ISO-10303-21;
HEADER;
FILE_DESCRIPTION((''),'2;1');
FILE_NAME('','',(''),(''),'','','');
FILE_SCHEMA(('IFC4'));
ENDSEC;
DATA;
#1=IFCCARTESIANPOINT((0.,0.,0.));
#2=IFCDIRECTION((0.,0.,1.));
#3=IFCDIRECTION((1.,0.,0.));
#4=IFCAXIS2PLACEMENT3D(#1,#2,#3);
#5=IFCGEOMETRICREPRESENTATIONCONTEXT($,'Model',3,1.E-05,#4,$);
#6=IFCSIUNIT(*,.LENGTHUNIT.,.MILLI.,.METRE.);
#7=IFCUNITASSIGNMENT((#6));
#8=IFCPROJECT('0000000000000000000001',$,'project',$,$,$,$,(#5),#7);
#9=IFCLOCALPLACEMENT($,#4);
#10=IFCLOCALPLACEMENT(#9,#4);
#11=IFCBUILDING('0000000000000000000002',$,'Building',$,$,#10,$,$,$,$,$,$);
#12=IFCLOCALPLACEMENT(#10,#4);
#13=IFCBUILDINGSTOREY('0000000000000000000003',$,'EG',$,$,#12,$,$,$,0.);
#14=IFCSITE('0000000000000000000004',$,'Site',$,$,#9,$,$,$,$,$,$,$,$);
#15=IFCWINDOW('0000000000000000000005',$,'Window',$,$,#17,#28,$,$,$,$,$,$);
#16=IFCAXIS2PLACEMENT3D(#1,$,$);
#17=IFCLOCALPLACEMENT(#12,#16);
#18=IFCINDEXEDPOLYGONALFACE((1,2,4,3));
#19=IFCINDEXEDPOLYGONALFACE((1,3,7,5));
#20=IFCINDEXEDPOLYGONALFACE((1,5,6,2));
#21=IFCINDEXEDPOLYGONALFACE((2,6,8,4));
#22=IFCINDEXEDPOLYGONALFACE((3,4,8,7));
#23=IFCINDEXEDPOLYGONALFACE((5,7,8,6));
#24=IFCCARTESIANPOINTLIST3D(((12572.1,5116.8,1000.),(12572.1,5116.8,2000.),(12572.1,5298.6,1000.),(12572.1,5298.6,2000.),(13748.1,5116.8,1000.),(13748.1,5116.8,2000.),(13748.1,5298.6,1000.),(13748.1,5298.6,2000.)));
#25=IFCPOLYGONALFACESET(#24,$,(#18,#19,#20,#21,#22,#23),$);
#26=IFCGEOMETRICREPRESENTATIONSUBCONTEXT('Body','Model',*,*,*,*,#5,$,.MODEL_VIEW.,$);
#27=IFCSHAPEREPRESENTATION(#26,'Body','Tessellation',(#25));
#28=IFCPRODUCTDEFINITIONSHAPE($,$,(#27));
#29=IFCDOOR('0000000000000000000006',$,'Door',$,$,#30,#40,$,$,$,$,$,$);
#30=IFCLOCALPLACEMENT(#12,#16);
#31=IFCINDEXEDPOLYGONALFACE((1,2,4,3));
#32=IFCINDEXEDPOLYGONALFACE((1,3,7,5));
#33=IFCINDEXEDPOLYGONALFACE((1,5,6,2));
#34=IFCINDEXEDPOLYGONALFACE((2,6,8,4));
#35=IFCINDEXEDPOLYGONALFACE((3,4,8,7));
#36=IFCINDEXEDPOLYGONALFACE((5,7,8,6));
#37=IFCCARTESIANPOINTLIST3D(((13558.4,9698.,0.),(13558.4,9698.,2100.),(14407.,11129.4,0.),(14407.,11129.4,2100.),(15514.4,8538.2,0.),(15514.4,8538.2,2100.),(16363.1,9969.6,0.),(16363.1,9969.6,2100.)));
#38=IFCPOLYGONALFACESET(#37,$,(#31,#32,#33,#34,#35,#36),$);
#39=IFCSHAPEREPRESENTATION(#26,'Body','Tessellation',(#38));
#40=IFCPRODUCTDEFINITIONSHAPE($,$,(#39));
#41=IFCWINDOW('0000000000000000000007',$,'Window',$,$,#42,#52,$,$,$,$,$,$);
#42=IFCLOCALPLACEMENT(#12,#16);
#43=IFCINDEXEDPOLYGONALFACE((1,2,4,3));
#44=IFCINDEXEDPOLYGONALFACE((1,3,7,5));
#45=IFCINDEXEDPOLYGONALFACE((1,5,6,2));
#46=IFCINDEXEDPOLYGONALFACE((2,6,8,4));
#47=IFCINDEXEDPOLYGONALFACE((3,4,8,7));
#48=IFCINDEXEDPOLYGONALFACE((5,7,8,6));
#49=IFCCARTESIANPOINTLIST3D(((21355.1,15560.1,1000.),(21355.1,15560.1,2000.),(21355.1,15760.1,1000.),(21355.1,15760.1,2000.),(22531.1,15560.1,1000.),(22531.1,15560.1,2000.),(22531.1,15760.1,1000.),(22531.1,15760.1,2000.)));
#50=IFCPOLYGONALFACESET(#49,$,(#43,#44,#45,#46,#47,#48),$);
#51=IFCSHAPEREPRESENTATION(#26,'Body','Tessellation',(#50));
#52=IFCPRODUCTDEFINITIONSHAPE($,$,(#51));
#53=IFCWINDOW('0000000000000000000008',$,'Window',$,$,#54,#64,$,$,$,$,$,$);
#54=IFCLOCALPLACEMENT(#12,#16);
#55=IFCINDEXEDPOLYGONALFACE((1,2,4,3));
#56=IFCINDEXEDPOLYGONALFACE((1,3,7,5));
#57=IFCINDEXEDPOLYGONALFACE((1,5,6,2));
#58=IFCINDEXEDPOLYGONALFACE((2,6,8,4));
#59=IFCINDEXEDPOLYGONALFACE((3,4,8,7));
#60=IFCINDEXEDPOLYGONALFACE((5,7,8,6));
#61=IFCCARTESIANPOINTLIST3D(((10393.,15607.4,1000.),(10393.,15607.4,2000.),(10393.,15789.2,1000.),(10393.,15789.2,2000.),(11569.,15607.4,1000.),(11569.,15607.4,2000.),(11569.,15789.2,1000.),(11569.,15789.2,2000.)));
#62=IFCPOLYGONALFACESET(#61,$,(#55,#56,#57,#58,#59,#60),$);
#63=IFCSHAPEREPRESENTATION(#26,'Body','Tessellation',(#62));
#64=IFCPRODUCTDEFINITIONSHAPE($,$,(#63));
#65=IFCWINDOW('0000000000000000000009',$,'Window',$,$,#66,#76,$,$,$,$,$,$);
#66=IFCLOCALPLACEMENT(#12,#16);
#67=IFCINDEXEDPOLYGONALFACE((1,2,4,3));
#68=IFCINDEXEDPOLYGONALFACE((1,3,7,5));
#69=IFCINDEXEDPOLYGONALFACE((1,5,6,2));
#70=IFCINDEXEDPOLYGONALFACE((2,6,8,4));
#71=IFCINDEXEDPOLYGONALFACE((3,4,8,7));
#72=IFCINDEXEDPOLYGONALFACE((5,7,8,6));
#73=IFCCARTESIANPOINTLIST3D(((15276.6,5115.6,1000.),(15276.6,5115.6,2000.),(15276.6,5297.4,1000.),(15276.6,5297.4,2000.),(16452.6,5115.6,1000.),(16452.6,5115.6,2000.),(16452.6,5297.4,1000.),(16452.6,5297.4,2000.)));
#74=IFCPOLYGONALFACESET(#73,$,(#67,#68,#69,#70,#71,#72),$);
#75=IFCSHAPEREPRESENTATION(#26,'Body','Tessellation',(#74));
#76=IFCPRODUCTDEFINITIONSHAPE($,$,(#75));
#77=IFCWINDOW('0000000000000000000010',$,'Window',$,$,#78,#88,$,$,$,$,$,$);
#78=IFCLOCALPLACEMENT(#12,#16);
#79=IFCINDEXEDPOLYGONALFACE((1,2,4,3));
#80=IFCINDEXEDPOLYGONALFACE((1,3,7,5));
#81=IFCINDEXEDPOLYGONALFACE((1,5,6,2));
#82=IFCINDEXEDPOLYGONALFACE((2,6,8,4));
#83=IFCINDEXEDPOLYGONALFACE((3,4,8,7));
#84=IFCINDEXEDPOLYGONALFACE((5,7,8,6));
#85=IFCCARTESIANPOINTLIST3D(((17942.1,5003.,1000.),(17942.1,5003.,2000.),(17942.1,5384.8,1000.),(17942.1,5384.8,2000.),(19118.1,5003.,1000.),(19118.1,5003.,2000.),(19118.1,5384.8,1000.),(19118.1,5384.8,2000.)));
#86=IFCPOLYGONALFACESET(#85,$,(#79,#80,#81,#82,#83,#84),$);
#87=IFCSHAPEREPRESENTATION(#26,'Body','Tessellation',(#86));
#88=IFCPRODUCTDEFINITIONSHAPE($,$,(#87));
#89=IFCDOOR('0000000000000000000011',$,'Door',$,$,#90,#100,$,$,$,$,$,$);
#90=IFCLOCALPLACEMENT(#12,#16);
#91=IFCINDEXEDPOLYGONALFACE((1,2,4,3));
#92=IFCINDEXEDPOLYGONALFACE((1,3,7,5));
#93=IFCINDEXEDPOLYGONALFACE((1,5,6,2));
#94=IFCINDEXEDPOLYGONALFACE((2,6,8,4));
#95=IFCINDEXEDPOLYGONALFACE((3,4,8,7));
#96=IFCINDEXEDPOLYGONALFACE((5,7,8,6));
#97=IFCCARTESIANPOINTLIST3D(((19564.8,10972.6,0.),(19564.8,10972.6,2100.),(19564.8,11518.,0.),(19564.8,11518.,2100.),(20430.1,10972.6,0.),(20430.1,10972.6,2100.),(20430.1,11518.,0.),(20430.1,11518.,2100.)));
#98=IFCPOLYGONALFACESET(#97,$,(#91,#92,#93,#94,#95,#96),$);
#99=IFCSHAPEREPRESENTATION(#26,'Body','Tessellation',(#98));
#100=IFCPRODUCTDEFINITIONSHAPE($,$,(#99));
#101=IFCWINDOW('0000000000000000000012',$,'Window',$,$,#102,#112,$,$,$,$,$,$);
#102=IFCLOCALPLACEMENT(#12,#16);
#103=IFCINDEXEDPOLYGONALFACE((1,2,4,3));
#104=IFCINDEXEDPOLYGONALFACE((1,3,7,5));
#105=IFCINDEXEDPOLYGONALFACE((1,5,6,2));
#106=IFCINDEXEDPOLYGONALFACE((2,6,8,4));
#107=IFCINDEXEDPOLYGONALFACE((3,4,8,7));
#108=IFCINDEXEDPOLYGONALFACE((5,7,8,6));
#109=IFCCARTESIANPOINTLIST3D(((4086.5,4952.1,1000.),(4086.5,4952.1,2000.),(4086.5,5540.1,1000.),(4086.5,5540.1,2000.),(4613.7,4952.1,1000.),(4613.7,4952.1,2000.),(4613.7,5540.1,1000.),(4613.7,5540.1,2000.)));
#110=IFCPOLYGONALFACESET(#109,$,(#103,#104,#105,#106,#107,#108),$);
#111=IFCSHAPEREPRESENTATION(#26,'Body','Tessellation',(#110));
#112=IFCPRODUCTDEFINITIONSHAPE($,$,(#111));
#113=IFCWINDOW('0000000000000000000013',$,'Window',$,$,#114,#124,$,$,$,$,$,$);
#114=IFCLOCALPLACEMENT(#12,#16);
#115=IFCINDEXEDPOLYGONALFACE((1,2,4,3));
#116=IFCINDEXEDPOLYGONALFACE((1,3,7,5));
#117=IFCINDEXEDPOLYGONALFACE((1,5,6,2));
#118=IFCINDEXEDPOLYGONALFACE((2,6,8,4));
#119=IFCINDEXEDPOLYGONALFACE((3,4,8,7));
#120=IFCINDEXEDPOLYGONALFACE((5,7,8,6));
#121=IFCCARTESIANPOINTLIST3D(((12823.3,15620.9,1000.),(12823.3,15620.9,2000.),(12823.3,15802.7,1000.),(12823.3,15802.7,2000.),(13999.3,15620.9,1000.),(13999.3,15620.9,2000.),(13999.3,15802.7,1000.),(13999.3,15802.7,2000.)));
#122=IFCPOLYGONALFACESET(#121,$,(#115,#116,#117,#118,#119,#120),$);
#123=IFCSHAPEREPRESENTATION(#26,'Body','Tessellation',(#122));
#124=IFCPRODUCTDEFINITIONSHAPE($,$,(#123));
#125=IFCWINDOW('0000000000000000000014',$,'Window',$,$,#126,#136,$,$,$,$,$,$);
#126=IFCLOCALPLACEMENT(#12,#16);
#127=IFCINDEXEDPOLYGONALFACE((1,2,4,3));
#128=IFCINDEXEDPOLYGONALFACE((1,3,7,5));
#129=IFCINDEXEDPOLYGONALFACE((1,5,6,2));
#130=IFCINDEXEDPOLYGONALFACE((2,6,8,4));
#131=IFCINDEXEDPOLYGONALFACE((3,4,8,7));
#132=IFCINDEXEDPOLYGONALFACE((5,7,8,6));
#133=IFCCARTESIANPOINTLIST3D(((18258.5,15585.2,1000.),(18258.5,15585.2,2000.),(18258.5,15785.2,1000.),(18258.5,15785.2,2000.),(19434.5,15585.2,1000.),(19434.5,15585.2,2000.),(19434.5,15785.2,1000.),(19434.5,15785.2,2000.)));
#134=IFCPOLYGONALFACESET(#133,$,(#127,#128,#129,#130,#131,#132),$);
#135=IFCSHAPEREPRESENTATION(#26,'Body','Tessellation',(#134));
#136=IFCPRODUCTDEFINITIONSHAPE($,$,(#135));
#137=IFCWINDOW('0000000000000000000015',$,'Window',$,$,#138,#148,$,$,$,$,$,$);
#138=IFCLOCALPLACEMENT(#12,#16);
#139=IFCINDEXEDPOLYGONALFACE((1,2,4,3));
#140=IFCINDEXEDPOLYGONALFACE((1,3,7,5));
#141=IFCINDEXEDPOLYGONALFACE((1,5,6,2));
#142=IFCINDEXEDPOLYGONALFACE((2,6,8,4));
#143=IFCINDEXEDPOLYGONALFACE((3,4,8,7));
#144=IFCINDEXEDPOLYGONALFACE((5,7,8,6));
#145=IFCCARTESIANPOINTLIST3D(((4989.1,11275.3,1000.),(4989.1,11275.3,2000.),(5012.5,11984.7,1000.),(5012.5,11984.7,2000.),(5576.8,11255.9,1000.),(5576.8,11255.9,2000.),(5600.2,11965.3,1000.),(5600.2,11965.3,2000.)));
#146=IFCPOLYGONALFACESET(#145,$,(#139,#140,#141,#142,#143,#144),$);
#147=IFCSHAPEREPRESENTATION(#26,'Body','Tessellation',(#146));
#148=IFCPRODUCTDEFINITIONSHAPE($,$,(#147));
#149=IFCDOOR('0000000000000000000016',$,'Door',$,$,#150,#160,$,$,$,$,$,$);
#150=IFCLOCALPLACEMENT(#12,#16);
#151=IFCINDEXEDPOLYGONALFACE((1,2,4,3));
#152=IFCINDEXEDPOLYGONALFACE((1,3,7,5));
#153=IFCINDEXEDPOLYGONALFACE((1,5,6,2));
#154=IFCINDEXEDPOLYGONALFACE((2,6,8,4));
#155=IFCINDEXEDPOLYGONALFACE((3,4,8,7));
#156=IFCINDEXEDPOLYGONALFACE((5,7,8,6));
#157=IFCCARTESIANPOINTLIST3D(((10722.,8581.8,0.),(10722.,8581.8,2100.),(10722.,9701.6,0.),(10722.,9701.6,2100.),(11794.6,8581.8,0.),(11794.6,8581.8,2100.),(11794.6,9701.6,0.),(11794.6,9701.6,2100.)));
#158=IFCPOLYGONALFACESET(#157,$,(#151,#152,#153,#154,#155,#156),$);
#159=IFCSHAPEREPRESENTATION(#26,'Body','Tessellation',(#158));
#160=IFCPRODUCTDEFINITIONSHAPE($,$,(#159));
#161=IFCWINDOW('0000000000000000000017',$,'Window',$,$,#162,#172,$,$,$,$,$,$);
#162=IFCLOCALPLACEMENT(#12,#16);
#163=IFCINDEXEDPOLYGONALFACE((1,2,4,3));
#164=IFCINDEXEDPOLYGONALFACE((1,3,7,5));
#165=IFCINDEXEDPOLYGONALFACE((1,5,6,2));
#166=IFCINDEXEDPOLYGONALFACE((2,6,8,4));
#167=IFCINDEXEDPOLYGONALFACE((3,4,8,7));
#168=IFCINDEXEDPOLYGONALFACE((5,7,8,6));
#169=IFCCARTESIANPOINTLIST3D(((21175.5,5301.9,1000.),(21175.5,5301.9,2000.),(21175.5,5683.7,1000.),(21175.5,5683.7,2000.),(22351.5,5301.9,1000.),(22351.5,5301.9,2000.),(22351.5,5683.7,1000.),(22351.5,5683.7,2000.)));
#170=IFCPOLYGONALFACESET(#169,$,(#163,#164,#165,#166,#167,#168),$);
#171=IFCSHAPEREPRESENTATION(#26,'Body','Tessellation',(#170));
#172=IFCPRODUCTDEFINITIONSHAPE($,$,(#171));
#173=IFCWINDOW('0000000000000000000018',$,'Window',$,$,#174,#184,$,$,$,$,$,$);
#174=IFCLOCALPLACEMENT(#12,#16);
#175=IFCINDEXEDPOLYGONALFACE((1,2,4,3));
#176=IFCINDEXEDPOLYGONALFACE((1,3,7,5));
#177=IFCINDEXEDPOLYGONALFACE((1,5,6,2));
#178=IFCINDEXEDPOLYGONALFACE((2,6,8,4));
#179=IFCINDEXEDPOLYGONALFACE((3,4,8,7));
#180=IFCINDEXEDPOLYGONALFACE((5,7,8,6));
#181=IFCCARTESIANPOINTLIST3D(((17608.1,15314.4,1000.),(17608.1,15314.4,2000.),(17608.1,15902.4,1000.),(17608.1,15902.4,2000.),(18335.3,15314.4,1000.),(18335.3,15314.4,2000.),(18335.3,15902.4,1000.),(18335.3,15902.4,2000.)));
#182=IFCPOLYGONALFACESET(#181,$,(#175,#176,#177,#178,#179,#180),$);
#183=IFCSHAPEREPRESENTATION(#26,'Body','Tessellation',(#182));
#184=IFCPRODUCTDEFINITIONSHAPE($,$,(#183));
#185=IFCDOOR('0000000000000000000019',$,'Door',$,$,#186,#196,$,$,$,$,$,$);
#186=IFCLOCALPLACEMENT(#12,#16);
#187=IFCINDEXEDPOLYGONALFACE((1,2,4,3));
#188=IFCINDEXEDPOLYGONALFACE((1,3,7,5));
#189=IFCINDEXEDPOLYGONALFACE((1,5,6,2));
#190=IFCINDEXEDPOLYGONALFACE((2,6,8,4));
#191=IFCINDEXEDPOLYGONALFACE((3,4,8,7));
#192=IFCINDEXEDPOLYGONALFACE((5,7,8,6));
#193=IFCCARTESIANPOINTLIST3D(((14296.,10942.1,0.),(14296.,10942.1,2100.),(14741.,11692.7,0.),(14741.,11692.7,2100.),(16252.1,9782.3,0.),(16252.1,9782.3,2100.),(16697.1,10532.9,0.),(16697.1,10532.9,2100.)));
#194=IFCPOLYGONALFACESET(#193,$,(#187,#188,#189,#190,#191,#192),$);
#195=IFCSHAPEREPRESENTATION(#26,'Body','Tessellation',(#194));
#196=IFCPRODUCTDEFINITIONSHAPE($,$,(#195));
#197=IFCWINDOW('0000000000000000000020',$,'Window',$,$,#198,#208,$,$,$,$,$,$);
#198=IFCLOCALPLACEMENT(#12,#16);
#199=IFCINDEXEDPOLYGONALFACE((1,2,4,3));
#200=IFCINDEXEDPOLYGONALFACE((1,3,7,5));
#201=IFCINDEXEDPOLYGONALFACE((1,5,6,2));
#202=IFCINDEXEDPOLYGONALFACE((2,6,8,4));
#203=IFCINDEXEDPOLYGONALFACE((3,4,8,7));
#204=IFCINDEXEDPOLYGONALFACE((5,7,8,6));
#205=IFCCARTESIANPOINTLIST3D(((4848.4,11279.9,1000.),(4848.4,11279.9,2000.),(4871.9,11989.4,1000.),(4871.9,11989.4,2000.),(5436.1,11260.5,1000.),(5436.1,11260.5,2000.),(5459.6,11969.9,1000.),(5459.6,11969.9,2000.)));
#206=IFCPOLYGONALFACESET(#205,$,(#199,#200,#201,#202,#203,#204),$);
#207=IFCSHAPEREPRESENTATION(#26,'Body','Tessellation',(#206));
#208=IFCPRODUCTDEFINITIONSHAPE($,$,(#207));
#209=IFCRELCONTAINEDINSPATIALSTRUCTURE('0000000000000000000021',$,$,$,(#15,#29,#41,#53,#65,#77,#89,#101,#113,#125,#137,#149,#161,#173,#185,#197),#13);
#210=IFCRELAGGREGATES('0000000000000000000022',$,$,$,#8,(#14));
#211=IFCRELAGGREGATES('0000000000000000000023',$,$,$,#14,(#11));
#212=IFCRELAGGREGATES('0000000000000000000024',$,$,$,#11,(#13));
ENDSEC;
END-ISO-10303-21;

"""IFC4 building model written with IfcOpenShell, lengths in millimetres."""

from ifc_helpers import new_model, si_unit, frame, origin_with_axes, place, context, subcontext, project, spatial, rectangle, extrude, element, save


model = new_model("IFC4")

# Units and contexts
model_context = context("Model", 3, precision=1e-05, world=origin_with_axes())
body_context = subcontext(model_context, "Body", "Model", "MODEL_VIEW")
ifc_project = project(units=[si_unit("LENGTHUNIT", "METRE", prefix="MILLI")], contexts=[model_context])

# Site, building, storey
site_placement = place(None, origin_with_axes())
site = spatial("IfcSite", under=ifc_project, at=site_placement, Name="Site")
building_placement = place(site_placement, origin_with_axes())
building = spatial("IfcBuilding", under=site, at=building_placement, Name="Building")
storey_placement = place(building_placement, origin_with_axes())
storey = spatial("IfcBuildingStorey", under=building, at=storey_placement, Name="EG", Elevation=0.0)

# Window
window_1_placement = place(storey_placement, origin_with_axes())
element("IfcWindow", 1, at=window_1_placement, inside=storey, Name="Window", context=body_context, shape_type="SweptSolid", body=[
    extrude(rectangle(XDim=1176.0, YDim=181.8), frame((13160.1, 5207.7, 1000.0), z_axis=(0.0, 0.0, 1.0), x_axis=(1.0, 0.0, 0.0)), (0.0, 0.0, 1.0), 1000.0),
])

# Door
door_1_placement = place(storey_placement, origin_with_axes())
element("IfcDoor", 2, at=door_1_placement, inside=storey, Name="Door", context=body_context, shape_type="SweptSolid", body=[
    extrude(rectangle(XDim=1664.0, YDim=2274.1), frame((14960.7, 9833.8, 0.0), z_axis=(0.0, 0.0, 1.0), x_axis=(-0.510011, -0.860168, 0.0)), (0.0, 0.0, 1.0), 2100.0),
])

# Windows
window_2_placement = place(storey_placement, origin_with_axes())
element("IfcWindow", 3, at=window_2_placement, inside=storey, Name="Window", context=body_context, shape_type="SweptSolid", body=[
    extrude(rectangle(XDim=1176.0, YDim=200.0), frame((21943.1, 15660.1, 1000.0), z_axis=(0.0, 0.0, 1.0), x_axis=(1.0, 0.0, 0.0)), (0.0, 0.0, 1.0), 1000.0),
])
window_3_placement = place(storey_placement, origin_with_axes())
element("IfcWindow", 4, at=window_3_placement, inside=storey, Name="Window", context=body_context, shape_type="SweptSolid", body=[
    extrude(rectangle(XDim=1176.0, YDim=181.8), frame((10981.0, 15698.3, 1000.0), z_axis=(0.0, 0.0, 1.0), x_axis=(1.0, 0.0, 0.0)), (0.0, 0.0, 1.0), 1000.0),
])
window_4_placement = place(storey_placement, origin_with_axes())
element("IfcWindow", 5, at=window_4_placement, inside=storey, Name="Window", context=body_context, shape_type="SweptSolid", body=[
    extrude(rectangle(XDim=1176.0, YDim=181.8), frame((15864.6, 5206.5, 1000.0), z_axis=(0.0, 0.0, 1.0), x_axis=(1.0, 0.0, 0.0)), (0.0, 0.0, 1.0), 1000.0),
])
window_5_placement = place(storey_placement, origin_with_axes())
element("IfcWindow", 6, at=window_5_placement, inside=storey, Name="Window", context=body_context, shape_type="SweptSolid", body=[
    extrude(rectangle(XDim=1176.0, YDim=381.8), frame((18530.1, 5193.9, 1000.0), z_axis=(0.0, 0.0, 1.0), x_axis=(1.0, 0.0, 0.0)), (0.0, 0.0, 1.0), 1000.0),
])

# Door
door_2_placement = place(storey_placement, origin_with_axes())
element("IfcDoor", 7, at=door_2_placement, inside=storey, Name="Door", context=body_context, shape_type="SweptSolid", body=[
    extrude(rectangle(XDim=865.3, YDim=545.4), frame((19997.4, 11245.3, 0.0), z_axis=(0.0, 0.0, 1.0), x_axis=(1.0, 0.0, 0.0)), (0.0, 0.0, 1.0), 2100.0),
])

# Windows
window_6_placement = place(storey_placement, origin_with_axes())
element("IfcWindow", 8, at=window_6_placement, inside=storey, Name="Window", context=body_context, shape_type="SweptSolid", body=[
    extrude(rectangle(XDim=588.0, YDim=527.2), frame((4350.1, 5246.1, 1000.0), z_axis=(0.0, 0.0, 1.0), x_axis=(0.0, 1.0, 0.0)), (0.0, 0.0, 1.0), 1000.0),
])
window_7_placement = place(storey_placement, origin_with_axes())
element("IfcWindow", 9, at=window_7_placement, inside=storey, Name="Window", context=body_context, shape_type="SweptSolid", body=[
    extrude(rectangle(XDim=1176.0, YDim=181.8), frame((13411.3, 15711.8, 1000.0), z_axis=(0.0, 0.0, 1.0), x_axis=(1.0, 0.0, 0.0)), (0.0, 0.0, 1.0), 1000.0),
])
window_8_placement = place(storey_placement, origin_with_axes())
element("IfcWindow", 10, at=window_8_placement, inside=storey, Name="Window", context=body_context, shape_type="SweptSolid", body=[
    extrude(rectangle(XDim=1176.0, YDim=200.0), frame((18846.5, 15685.2, 1000.0), z_axis=(0.0, 0.0, 1.0), x_axis=(1.0, 0.0, 0.0)), (0.0, 0.0, 1.0), 1000.0),
])
window_9_placement = place(storey_placement, origin_with_axes())
element("IfcWindow", 11, at=window_9_placement, inside=storey, Name="Window", context=body_context, shape_type="SweptSolid", body=[
    extrude(rectangle(XDim=588.0, YDim=709.8), frame((5294.6, 11620.3, 1000.0), z_axis=(0.0, 0.0, 1.0), x_axis=(0.999454, -0.03304, 0.0)), (0.0, 0.0, 1.0), 1000.0),
])

# Door
door_3_placement = place(storey_placement, origin_with_axes())
element("IfcDoor", 12, at=door_3_placement, inside=storey, Name="Door", context=body_context, shape_type="SweptSolid", body=[
    extrude(rectangle(XDim=1119.9, YDim=1072.6), frame((11258.3, 9141.7, 0.0), z_axis=(0.0, 0.0, 1.0), x_axis=(0.0, 1.0, 0.0)), (0.0, 0.0, 1.0), 2100.0),
])

# Windows
window_10_placement = place(storey_placement, origin_with_axes())
element("IfcWindow", 13, at=window_10_placement, inside=storey, Name="Window", context=body_context, shape_type="SweptSolid", body=[
    extrude(rectangle(XDim=1176.0, YDim=381.8), frame((21763.5, 5492.8, 1000.0), z_axis=(0.0, 0.0, 1.0), x_axis=(1.0, 0.0, 0.0)), (0.0, 0.0, 1.0), 1000.0),
])
window_11_placement = place(storey_placement, origin_with_axes())
element("IfcWindow", 14, at=window_11_placement, inside=storey, Name="Window", context=body_context, shape_type="SweptSolid", body=[
    extrude(rectangle(XDim=588.0, YDim=727.2), frame((17971.7, 15608.4, 1000.0), z_axis=(0.0, 0.0, 1.0), x_axis=(0.0, 1.0, 0.0)), (0.0, 0.0, 1.0), 1000.0),
])

# Door
door_4_placement = place(storey_placement, origin_with_axes())
element("IfcDoor", 15, at=door_4_placement, inside=storey, Name="Door", context=body_context, shape_type="SweptSolid", body=[
    extrude(rectangle(XDim=872.6, YDim=2274.1), frame((15496.6, 10737.5, 0.0), z_axis=(0.0, 0.0, 1.0), x_axis=(-0.510011, -0.860168, 0.0)), (0.0, 0.0, 1.0), 2100.0),
])

# Window
window_12_placement = place(storey_placement, origin_with_axes())
element("IfcWindow", 16, at=window_12_placement, inside=storey, Name="Window", context=body_context, shape_type="SweptSolid", body=[
    extrude(rectangle(XDim=588.0, YDim=709.8), frame((5154.0, 11624.9, 1000.0), z_axis=(0.0, 0.0, 1.0), x_axis=(0.999454, -0.03304, 0.0)), (0.0, 0.0, 1.0), 1000.0),
])

save(model, "model.ifc")
